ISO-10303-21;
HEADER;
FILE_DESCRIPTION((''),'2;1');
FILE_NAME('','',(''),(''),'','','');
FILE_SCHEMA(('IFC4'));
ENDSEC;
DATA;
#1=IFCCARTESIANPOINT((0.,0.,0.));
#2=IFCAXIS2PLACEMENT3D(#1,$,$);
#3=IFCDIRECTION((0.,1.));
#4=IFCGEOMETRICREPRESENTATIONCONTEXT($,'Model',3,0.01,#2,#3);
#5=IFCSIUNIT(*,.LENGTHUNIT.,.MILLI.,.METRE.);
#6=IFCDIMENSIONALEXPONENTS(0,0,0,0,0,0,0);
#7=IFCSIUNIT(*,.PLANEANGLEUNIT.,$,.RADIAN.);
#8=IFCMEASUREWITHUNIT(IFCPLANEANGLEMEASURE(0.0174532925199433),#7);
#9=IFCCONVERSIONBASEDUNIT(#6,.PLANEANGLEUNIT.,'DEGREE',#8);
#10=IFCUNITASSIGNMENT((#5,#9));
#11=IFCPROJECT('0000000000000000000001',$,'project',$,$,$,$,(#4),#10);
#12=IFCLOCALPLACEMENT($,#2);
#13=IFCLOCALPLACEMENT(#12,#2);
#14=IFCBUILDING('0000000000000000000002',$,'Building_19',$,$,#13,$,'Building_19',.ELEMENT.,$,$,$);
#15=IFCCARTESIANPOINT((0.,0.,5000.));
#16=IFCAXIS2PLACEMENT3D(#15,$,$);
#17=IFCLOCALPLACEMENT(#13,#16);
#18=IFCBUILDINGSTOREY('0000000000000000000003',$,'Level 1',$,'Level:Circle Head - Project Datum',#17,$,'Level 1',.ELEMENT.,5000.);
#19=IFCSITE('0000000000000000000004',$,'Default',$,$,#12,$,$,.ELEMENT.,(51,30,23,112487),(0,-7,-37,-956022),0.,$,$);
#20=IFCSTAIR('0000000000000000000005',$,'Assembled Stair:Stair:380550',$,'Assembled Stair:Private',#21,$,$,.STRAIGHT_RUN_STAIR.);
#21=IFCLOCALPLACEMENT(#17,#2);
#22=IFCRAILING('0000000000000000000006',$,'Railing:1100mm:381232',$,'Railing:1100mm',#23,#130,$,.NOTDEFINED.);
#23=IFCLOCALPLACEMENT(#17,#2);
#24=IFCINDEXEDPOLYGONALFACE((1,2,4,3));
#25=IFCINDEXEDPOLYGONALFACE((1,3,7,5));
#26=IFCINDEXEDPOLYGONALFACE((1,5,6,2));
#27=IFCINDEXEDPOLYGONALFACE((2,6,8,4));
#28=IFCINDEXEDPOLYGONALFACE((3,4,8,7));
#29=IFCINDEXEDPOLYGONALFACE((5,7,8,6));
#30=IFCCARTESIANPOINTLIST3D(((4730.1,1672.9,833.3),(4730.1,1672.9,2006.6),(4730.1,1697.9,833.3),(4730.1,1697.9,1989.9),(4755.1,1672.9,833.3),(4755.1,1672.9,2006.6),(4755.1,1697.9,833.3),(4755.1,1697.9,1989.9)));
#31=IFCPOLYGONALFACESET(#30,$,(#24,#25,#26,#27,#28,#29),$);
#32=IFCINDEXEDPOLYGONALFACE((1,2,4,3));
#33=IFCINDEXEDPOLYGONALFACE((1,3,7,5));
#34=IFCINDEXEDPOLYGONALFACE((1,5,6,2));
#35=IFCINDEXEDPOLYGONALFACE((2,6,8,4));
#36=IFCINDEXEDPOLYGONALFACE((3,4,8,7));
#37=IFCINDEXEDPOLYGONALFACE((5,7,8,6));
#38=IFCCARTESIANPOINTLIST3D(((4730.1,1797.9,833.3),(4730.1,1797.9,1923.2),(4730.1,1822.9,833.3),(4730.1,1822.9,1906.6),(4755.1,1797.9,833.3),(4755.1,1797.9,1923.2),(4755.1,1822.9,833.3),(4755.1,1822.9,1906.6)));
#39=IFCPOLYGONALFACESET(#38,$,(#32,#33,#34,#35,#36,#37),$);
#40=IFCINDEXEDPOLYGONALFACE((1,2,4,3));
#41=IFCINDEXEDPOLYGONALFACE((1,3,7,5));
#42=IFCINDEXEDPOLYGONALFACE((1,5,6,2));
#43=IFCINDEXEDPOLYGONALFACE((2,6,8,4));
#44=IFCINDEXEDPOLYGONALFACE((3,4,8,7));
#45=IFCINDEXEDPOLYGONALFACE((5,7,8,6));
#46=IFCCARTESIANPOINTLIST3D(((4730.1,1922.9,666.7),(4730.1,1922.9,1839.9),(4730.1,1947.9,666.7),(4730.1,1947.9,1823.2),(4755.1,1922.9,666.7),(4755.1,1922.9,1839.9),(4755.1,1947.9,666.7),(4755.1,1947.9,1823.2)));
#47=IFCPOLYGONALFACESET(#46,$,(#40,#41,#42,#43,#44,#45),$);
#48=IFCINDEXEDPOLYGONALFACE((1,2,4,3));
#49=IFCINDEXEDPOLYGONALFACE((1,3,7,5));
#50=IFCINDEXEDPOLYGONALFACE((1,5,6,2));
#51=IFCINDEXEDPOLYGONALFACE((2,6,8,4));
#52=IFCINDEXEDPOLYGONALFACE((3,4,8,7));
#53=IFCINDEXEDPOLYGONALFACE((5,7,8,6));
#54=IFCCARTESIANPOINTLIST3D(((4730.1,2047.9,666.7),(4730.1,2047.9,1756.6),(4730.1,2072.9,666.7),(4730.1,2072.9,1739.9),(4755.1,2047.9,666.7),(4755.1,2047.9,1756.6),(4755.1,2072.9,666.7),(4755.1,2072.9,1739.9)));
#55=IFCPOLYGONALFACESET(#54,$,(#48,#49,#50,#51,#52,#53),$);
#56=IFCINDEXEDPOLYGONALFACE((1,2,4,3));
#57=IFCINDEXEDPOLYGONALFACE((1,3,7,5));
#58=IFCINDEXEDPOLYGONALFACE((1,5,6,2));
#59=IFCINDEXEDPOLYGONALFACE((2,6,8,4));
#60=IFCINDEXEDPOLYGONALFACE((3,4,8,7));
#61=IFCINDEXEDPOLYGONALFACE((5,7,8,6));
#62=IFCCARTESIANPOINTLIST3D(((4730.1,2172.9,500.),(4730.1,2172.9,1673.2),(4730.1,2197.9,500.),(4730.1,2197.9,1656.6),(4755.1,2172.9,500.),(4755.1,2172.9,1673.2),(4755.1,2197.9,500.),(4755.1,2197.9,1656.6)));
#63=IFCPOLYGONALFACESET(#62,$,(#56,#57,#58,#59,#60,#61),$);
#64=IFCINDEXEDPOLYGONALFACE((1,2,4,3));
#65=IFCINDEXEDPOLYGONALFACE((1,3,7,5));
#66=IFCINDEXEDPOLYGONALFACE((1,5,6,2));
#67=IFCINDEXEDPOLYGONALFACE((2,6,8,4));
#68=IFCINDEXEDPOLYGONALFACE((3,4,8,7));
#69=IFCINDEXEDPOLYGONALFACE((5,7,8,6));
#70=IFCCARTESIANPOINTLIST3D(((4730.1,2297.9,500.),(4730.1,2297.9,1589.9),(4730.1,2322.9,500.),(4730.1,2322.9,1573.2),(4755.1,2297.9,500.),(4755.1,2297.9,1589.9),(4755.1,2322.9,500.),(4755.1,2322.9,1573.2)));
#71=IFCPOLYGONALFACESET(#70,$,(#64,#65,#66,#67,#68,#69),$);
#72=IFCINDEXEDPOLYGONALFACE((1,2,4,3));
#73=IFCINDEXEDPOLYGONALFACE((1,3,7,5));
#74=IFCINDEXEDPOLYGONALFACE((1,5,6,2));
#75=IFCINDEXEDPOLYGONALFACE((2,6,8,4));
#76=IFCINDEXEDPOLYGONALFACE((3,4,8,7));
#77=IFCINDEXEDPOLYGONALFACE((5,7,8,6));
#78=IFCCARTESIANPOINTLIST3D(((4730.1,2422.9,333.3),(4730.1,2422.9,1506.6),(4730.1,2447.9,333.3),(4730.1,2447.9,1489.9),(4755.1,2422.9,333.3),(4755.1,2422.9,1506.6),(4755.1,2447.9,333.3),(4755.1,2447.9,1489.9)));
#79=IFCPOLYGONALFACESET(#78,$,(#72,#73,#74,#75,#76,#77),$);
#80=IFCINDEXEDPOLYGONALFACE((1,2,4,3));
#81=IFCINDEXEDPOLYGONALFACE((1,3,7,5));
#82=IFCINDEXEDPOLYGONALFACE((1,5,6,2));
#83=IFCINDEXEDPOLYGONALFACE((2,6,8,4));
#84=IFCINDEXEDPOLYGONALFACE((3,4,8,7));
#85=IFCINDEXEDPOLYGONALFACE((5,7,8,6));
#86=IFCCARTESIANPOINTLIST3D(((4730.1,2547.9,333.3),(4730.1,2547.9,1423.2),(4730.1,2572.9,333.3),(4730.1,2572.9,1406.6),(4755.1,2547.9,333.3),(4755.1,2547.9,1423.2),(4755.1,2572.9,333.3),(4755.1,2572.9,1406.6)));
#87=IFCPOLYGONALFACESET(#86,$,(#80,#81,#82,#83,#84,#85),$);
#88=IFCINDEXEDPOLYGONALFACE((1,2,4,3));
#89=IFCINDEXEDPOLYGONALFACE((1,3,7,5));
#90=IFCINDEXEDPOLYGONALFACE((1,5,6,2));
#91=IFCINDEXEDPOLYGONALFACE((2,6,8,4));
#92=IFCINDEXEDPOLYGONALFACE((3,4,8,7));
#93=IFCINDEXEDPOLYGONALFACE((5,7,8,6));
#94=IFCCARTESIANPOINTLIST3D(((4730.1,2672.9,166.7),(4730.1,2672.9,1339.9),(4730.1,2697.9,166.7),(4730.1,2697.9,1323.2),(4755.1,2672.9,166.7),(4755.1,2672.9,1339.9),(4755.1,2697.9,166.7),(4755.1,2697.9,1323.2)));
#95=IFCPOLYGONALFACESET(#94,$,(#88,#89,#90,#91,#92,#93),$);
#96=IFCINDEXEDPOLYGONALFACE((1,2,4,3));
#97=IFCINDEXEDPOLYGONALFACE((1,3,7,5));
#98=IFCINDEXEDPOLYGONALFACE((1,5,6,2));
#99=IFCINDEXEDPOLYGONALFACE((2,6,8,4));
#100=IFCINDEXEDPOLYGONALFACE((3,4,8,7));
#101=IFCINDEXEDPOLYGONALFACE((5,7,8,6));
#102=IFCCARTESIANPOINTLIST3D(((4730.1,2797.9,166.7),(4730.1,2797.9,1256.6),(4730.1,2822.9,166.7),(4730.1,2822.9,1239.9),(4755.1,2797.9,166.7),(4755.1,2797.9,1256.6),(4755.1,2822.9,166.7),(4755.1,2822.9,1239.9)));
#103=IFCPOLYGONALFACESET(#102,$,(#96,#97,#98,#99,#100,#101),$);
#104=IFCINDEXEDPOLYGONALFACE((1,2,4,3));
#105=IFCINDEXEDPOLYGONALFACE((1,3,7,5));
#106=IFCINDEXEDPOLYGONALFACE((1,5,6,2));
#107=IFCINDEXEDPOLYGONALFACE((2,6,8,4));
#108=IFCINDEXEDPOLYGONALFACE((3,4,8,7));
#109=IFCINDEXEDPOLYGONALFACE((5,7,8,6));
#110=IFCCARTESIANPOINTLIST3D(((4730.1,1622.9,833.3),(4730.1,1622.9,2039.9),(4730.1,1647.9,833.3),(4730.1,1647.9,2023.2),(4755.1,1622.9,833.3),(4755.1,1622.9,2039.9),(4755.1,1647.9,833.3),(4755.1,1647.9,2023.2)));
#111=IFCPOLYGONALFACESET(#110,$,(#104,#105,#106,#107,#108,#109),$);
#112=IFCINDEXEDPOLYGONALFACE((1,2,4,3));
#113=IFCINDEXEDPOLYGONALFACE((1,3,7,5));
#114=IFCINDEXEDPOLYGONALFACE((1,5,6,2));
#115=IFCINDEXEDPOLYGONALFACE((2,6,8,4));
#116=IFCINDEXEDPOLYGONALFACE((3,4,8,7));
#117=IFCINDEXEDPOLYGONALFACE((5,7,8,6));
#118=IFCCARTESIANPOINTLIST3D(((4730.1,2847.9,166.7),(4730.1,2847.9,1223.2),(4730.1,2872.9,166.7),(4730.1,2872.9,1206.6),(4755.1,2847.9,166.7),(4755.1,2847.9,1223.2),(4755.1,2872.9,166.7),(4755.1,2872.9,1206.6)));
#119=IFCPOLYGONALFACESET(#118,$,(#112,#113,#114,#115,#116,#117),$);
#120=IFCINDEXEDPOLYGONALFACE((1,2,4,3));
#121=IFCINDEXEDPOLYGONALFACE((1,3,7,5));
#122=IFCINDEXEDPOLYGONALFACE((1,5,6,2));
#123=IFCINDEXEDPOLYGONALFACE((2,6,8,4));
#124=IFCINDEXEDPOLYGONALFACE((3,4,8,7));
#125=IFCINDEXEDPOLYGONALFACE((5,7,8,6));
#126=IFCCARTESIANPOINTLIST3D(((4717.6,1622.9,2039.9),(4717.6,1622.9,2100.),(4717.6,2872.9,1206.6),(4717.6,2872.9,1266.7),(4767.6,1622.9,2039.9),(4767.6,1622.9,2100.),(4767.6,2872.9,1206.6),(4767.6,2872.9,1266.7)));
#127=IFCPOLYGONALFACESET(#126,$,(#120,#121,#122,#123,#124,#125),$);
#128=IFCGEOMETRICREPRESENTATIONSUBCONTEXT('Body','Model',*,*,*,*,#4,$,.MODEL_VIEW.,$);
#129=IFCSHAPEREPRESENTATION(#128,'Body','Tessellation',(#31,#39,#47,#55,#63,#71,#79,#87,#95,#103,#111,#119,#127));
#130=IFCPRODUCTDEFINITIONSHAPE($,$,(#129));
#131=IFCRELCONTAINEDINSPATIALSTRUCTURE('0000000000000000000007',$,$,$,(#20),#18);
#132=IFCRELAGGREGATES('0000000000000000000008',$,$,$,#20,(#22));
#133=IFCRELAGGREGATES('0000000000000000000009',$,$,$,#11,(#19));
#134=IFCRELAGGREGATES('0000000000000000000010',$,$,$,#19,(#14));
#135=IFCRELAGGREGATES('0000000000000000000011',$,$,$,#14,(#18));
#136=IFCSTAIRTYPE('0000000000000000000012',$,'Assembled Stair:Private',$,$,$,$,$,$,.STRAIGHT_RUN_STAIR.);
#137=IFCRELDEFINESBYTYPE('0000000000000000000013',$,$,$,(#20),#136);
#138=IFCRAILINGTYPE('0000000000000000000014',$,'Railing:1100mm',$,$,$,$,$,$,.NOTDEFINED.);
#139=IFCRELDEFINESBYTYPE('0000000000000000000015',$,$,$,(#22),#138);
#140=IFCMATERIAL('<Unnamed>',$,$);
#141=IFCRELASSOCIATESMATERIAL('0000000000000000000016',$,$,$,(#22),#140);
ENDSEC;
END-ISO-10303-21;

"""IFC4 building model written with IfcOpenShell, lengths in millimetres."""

from ifc_helpers import new_model, entity, si_unit, converted_unit, direction, frame, origin, place, context, subcontext, project, spatial, indexed_curve, outline, extrude, material, type_object, element, aggregate, save


model = new_model("IFC4")

# Units and contexts
model_context = context("Model", 3, precision=0.01, world=origin(), true_north=direction((0.0, 1.0)))
body_context = subcontext(model_context, "Body", "Model", "MODEL_VIEW")
ifc_project = project(units=[si_unit("LENGTHUNIT", "METRE", prefix="MILLI"), converted_unit("PLANEANGLEUNIT", "DEGREE", entity("IfcPlaneAngleMeasure", 0.0174532925199433), si_unit("PLANEANGLEUNIT", "RADIAN"), dimensions=[0, 0, 0, 0, 0, 0, 0])], contexts=[model_context])

# Site, building, storey
site_placement = place(None, origin())
site = spatial("IfcSite", under=ifc_project, at=site_placement, Name="Default", CompositionType="ELEMENT", RefLatitude=(51, 30, 23, 112487), RefLongitude=(0, -7, -37, -956022), RefElevation=0.0)
building_placement = place(site_placement, origin())
building = spatial("IfcBuilding", under=site, at=building_placement, Name="Building_19", LongName="Building_19", CompositionType="ELEMENT")
storey_placement = place(building_placement, frame((0.0, 0.0, 5000.0)))
storey = spatial("IfcBuildingStorey", under=building, at=storey_placement, Name="Level 1", ObjectType="Level:Circle Head - Project Datum", LongName="Level 1", CompositionType="ELEMENT", Elevation=5000.0)

# Stair
stair_type = type_object("IfcStairType", Name="Assembled Stair:Private", PredefinedType="STRAIGHT_RUN_STAIR")
ifc_material_1 = material(Name="<Unnamed>")
stair_1_placement = place(storey_placement, origin())
stair_1 = element("IfcStair", 1, at=stair_1_placement, inside=storey, type_object=stair_type, Name="Assembled Stair:Stair:380550", ObjectType="Assembled Stair:Private", PredefinedType="STRAIGHT_RUN_STAIR")

# Railing
railing_type = type_object("IfcRailingType", Name="Railing:1100mm", PredefinedType="NOTDEFINED")
railing_1_placement = place(stair_1_placement, origin())
railing_1 = element("IfcRailing", 2, at=railing_1_placement, type_object=railing_type, material=ifc_material_1, Name="Railing:1100mm:381232", ObjectType="Railing:1100mm", PredefinedType="NOTDEFINED", context=body_context, shape_type="SweptSolid", body=[
    extrude(outline(indexed_curve([(-582.5, -12.5), (574.1, -12.5), (590.8, 12.5), (-582.5, 12.5), (-582.5, -12.5)], self_intersect=False)), frame((4730.1, 1685.4, 1415.8), z_axis=(1.0, 0.0, 0.0), x_axis=(0.0, 0.0, 1.0)), (0.0, 0.0, 1.0), 25.0),
    extrude(outline(indexed_curve([(-540.8, -12.5), (532.5, -12.5), (549.1, 12.5), (-540.8, 12.5), (-540.8, -12.5)], self_intersect=False)), frame((4730.1, 1810.4, 1374.1), z_axis=(1.0, 0.0, 0.0), x_axis=(0.0, 0.0, 1.0)), (0.0, 0.0, 1.0), 25.0),
    extrude(outline(indexed_curve([(-582.5, -12.5), (574.1, -12.5), (590.8, 12.5), (-582.5, 12.5), (-582.5, -12.5)], self_intersect=False)), frame((4730.1, 1935.4, 1249.1), z_axis=(1.0, 0.0, 0.0), x_axis=(0.0, 0.0, 1.0)), (0.0, 0.0, 1.0), 25.0),
    extrude(outline(indexed_curve([(-540.8, -12.5), (532.5, -12.5), (549.1, 12.5), (-540.8, 12.5), (-540.8, -12.5)], self_intersect=False)), frame((4730.1, 2060.4, 1207.5), z_axis=(1.0, 0.0, 0.0), x_axis=(0.0, 0.0, 1.0)), (0.0, 0.0, 1.0), 25.0),
    extrude(outline(indexed_curve([(-582.5, -12.5), (574.1, -12.5), (590.8, 12.5), (-582.5, 12.5), (-582.5, -12.5)], self_intersect=False)), frame((4730.1, 2185.4, 1082.5), z_axis=(1.0, 0.0, 0.0), x_axis=(0.0, 0.0, 1.0)), (0.0, 0.0, 1.0), 25.0),
    extrude(outline(indexed_curve([(-540.8, -12.5), (532.5, -12.5), (549.1, 12.5), (-540.8, 12.5), (-540.8, -12.5)], self_intersect=False)), frame((4730.1, 2310.4, 1040.8), z_axis=(1.0, 0.0, 0.0), x_axis=(0.0, 0.0, 1.0)), (0.0, 0.0, 1.0), 25.0),
    extrude(outline(indexed_curve([(-582.5, -12.5), (574.1, -12.5), (590.8, 12.5), (-582.5, 12.5), (-582.5, -12.5)], self_intersect=False)), frame((4730.1, 2435.4, 915.8), z_axis=(1.0, 0.0, 0.0), x_axis=(0.0, 0.0, 1.0)), (0.0, 0.0, 1.0), 25.0),
    extrude(outline(indexed_curve([(-540.8, -12.5), (532.5, -12.5), (549.1, 12.5), (-540.8, 12.5), (-540.8, -12.5)], self_intersect=False)), frame((4730.1, 2560.4, 874.1), z_axis=(1.0, 0.0, 0.0), x_axis=(0.0, 0.0, 1.0)), (0.0, 0.0, 1.0), 25.0),
    extrude(outline(indexed_curve([(-582.5, -12.5), (574.1, -12.5), (590.8, 12.5), (-582.5, 12.5), (-582.5, -12.5)], self_intersect=False)), frame((4730.1, 2685.4, 749.1), z_axis=(1.0, 0.0, 0.0), x_axis=(0.0, 0.0, 1.0)), (0.0, 0.0, 1.0), 25.0),
    extrude(outline(indexed_curve([(-540.8, -12.5), (532.5, -12.5), (549.1, 12.5), (-540.8, 12.5), (-540.8, -12.5)], self_intersect=False)), frame((4730.1, 2810.4, 707.5), z_axis=(1.0, 0.0, 0.0), x_axis=(0.0, 0.0, 1.0)), (0.0, 0.0, 1.0), 25.0),
    extrude(outline(indexed_curve([(-599.1, -12.5), (590.8, -12.5), (607.5, 12.5), (-599.1, 12.5), (-599.1, -12.5)], self_intersect=False)), frame((4730.1, 1635.4, 1432.5), z_axis=(1.0, 0.0, 0.0), x_axis=(0.0, 0.0, 1.0)), (0.0, 0.0, 1.0), 25.0),
    extrude(outline(indexed_curve([(-524.1, -12.5), (515.8, -12.5), (532.5, 12.5), (-524.1, 12.5), (-524.1, -12.5)], self_intersect=False)), frame((4730.1, 2860.4, 690.8), z_axis=(1.0, 0.0, 0.0), x_axis=(0.0, 0.0, 1.0)), (0.0, 0.0, 1.0), 25.0),
    extrude(outline(indexed_curve([(-734.5, -25.0), (767.8, -25.0), (734.5, 25.0), (-767.8, 25.0), (-734.5, -25.0)], self_intersect=False)), frame((4717.6, 2247.9, 1653.3), z_axis=(1.0, 0.0, 0.0), x_axis=(0.0, -0.83205, 0.5547)), (0.0, 0.0, 1.0), 50.0),
])
aggregate(stair_1, [railing_1])

save(model, "model.ifc")
